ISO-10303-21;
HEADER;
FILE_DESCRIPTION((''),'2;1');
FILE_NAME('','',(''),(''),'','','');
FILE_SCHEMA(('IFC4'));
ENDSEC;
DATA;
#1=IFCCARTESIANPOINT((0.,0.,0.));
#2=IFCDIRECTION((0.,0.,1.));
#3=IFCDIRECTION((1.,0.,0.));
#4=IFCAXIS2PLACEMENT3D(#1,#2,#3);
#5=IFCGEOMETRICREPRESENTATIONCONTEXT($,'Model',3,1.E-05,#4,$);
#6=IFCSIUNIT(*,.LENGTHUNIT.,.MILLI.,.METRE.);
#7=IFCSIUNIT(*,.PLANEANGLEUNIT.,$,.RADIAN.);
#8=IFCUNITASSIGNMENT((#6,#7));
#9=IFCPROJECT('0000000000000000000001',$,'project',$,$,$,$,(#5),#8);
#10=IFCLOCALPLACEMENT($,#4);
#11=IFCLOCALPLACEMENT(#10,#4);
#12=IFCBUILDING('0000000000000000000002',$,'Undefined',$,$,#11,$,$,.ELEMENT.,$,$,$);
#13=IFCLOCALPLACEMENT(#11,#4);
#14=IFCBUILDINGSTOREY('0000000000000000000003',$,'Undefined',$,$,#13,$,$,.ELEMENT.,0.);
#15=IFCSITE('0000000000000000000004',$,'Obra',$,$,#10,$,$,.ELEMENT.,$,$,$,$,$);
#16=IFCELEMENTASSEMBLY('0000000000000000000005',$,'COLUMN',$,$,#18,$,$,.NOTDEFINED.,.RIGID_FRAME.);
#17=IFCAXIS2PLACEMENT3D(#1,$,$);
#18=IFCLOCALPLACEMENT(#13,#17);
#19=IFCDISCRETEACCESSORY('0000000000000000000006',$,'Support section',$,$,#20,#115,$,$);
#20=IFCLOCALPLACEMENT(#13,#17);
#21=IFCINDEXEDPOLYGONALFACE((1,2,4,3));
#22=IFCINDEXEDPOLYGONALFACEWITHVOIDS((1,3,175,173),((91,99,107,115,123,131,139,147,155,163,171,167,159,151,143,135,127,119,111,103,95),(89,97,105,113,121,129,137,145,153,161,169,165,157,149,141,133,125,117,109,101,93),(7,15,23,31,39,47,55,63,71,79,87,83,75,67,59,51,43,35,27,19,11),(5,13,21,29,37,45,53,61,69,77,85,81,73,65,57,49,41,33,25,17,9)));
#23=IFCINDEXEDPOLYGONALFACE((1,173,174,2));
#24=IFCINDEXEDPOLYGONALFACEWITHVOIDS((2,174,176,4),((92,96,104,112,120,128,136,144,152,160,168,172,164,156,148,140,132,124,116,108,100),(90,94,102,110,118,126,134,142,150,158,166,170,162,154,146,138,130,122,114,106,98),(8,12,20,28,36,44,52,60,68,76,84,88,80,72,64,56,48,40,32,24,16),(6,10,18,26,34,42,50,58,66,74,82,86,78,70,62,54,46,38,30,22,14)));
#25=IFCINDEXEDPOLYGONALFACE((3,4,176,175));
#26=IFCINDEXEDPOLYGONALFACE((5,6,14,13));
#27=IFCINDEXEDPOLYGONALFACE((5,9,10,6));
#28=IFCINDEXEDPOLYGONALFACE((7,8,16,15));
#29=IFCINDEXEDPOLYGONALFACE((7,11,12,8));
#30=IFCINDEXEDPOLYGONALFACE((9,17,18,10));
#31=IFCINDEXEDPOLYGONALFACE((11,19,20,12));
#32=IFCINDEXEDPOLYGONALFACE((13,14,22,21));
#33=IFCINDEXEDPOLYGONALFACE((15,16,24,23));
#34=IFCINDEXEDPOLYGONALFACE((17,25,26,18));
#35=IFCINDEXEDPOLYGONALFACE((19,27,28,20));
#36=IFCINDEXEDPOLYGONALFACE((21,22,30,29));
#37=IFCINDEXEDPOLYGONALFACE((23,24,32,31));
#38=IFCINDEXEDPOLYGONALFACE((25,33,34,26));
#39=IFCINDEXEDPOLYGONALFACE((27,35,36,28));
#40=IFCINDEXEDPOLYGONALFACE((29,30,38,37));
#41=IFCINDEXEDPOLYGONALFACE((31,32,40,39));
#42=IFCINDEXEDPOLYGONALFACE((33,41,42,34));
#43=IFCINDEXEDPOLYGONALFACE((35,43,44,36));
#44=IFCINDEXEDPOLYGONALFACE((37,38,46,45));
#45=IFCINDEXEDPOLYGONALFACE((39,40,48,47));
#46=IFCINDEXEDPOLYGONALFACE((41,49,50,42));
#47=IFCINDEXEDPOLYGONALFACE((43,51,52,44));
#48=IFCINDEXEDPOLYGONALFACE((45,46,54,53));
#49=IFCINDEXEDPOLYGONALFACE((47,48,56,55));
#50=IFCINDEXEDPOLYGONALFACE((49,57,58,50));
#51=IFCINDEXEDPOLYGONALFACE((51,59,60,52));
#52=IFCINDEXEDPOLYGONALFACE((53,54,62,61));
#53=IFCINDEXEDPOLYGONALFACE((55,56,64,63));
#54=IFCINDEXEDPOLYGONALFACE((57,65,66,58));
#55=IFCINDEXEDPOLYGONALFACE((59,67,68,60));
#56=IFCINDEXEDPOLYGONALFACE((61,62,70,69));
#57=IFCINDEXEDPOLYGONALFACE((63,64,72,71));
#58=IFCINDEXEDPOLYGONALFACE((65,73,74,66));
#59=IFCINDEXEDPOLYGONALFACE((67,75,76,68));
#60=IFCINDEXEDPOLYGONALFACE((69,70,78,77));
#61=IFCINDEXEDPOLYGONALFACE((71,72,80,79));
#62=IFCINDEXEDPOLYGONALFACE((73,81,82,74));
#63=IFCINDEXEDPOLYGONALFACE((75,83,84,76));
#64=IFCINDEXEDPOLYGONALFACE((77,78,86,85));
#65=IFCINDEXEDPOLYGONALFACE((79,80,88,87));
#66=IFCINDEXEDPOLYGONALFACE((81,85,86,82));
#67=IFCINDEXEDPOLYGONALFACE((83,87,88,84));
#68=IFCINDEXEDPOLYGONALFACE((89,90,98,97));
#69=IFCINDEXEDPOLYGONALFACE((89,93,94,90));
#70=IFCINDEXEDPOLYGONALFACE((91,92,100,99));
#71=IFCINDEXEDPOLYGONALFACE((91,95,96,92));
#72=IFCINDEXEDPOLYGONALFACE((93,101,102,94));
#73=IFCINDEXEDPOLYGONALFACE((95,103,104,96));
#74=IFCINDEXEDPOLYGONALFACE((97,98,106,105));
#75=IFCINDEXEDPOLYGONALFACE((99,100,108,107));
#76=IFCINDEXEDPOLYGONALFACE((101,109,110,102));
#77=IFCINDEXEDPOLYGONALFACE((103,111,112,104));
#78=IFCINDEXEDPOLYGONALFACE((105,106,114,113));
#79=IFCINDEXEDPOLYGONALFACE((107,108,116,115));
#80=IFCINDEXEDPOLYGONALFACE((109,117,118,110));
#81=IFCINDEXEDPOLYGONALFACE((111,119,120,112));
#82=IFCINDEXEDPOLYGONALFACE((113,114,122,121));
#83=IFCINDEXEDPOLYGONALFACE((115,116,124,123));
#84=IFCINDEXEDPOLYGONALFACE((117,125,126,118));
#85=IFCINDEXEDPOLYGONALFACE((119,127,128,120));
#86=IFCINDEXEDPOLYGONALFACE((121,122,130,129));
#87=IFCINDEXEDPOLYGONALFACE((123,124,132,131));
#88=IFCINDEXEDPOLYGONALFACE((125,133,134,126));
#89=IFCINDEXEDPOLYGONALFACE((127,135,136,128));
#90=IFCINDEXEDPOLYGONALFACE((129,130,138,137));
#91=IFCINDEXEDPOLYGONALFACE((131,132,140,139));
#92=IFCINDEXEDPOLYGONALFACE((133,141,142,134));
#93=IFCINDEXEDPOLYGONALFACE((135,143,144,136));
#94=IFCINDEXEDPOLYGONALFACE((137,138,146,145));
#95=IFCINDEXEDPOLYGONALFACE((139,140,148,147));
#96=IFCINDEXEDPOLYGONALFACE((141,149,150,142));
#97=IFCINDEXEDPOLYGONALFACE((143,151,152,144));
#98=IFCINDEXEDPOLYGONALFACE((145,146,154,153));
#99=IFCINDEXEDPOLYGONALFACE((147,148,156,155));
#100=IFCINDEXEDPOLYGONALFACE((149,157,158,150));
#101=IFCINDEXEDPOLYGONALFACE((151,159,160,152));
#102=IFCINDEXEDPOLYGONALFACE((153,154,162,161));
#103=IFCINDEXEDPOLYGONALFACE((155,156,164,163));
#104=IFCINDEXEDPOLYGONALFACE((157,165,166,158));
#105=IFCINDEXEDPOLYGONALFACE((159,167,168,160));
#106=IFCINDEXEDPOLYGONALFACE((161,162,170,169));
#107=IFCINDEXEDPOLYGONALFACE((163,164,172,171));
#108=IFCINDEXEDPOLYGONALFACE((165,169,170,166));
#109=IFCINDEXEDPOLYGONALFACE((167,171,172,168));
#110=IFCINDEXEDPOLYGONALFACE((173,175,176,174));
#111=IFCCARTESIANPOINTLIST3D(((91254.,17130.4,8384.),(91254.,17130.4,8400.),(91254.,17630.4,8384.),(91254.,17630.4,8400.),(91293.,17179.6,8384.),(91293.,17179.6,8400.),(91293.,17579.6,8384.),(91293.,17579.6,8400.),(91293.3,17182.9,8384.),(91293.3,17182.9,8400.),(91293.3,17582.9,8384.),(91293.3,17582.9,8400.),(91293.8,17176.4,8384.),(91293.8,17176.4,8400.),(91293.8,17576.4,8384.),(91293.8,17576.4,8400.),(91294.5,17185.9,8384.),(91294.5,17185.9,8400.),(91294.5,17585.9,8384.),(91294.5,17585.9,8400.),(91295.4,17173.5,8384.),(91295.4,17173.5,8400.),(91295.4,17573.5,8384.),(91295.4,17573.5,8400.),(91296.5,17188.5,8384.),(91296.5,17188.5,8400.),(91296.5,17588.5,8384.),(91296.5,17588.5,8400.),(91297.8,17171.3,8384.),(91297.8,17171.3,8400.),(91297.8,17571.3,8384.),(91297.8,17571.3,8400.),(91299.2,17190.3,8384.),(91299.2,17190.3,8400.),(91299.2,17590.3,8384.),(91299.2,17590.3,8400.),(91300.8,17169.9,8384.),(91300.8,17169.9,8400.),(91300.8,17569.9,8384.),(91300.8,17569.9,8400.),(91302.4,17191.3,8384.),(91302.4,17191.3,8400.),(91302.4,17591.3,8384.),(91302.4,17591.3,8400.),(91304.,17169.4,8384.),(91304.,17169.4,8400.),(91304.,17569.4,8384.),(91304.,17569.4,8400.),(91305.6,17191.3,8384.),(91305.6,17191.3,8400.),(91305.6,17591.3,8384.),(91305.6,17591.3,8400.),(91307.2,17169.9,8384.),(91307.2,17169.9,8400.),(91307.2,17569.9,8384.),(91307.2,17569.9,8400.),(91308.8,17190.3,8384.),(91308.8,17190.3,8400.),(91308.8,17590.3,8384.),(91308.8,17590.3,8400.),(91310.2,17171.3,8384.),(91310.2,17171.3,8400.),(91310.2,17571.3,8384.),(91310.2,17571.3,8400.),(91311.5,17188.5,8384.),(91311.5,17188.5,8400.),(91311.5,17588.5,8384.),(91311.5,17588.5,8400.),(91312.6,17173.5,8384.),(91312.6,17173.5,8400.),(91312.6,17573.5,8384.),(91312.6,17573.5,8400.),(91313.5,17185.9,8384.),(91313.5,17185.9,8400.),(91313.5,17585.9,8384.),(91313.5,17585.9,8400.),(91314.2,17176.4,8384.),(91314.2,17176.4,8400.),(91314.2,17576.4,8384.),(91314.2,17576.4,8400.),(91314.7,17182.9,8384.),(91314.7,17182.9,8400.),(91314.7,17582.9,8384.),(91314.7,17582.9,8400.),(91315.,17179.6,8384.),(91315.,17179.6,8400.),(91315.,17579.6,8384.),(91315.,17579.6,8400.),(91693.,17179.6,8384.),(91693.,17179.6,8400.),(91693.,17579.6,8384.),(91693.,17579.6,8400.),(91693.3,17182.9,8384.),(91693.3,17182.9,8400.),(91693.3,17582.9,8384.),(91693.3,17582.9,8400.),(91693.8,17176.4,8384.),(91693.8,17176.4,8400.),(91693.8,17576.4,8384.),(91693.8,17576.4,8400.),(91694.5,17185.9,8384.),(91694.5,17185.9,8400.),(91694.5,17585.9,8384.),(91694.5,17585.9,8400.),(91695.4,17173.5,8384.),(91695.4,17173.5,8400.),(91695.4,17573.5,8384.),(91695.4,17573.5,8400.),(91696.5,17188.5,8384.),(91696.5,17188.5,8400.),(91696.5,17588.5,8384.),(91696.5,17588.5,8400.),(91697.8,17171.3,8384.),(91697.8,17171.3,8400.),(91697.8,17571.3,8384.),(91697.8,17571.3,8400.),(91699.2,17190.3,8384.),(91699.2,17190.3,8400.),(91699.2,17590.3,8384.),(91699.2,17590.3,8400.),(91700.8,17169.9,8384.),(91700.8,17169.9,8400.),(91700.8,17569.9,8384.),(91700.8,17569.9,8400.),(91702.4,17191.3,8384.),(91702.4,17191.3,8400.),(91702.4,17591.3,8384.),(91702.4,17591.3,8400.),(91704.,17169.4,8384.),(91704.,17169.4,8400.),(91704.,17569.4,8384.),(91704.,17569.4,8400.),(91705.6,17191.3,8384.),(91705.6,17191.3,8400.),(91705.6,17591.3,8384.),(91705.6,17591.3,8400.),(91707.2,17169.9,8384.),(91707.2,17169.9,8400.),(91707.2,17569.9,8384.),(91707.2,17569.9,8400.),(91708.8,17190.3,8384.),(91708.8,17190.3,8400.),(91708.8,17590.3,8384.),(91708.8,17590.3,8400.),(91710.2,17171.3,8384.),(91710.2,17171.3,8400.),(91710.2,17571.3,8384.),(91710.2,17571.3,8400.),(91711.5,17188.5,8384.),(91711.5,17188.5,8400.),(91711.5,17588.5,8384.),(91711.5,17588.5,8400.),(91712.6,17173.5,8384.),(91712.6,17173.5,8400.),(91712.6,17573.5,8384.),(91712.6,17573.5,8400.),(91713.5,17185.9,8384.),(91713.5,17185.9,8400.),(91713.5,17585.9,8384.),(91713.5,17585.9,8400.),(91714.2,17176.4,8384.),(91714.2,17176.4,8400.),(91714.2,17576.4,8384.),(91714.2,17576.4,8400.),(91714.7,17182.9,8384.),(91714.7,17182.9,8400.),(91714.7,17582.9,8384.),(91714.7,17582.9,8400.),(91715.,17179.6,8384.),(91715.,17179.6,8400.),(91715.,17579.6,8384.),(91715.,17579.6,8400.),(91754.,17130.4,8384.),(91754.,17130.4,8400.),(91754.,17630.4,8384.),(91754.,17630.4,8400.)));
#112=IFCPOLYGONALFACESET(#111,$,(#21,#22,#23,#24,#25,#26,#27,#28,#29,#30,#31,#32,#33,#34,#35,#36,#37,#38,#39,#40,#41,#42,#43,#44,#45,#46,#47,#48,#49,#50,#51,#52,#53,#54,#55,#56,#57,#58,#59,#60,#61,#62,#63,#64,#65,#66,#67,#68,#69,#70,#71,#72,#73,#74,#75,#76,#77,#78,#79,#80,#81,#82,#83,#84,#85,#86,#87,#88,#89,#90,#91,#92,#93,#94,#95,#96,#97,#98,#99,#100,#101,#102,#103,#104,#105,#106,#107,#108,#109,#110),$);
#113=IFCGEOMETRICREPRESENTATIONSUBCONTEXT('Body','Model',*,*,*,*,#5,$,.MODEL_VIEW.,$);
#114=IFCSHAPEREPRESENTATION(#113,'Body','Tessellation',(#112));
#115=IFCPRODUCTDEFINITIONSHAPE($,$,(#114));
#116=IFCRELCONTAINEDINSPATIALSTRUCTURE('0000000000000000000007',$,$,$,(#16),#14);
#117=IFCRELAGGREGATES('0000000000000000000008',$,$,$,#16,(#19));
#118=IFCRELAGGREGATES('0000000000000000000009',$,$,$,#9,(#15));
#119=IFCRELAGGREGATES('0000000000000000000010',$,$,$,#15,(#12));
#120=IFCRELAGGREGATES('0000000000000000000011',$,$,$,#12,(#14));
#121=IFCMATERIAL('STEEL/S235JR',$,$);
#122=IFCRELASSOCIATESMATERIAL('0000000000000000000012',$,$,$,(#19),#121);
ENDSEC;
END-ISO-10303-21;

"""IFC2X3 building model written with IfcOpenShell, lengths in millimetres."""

from ifc_helpers import new_model, si_unit, frame, origin_with_axes, origin_2d_with_axis, place, context, subcontext, project, spatial, rectangle, circle, extrude, source, transform, mapped, material, element, aggregate, save


model = new_model("IFC2X3")

# Units and contexts
model_context = context("Model", 3, precision=1e-05, world=origin_with_axes())
body_context = subcontext(model_context, "Body", "Model", "MODEL_VIEW")
ifc_project = project(units=[si_unit("LENGTHUNIT", "METRE", prefix="MILLI"), si_unit("PLANEANGLEUNIT", "RADIAN")], contexts=[model_context])

# Site, building, storey
site_placement = place(None, origin_with_axes())
site = spatial("IfcSite", under=ifc_project, at=site_placement, Name="Obra", CompositionType="ELEMENT")
building_placement = place(site_placement, origin_with_axes())
building = spatial("IfcBuilding", under=site, at=building_placement, Name="Undefined", CompositionType="ELEMENT")
storey_placement = place(building_placement, origin_with_axes())
storey = spatial("IfcBuildingStorey", under=building, at=storey_placement, Name="Undefined", CompositionType="ELEMENT", Elevation=0.0)

# Element assembly
assembly_1_placement = place(storey_placement, origin_with_axes())
assembly_1 = element("IfcElementAssembly", 1, at=assembly_1_placement, inside=storey, Name="COLUMN", AssemblyPlace="NOTDEFINED", PredefinedType="RIGID_FRAME")
ifc_material_1 = material(Name="STEEL/S235JR")

# Discrete accessory, opening
discrete_accessory_1_placement = place(assembly_1_placement, frame((91504.0, 17130.4, 8392.0), z_axis=(-1.0, 0.0, 0.0), x_axis=(0.0, 1.0, 0.0)))
discrete_accessory_1 = element("IfcDiscreteAccessory", 2, at=discrete_accessory_1_placement, material=ifc_material_1, Name="Support section", context=body_context, shape_type="SweptSolid", body=[
    extrude(rectangle(XDim=16.0, YDim=500.0, at=origin_2d_with_axis()), frame((500.0, 0.0, 0.0), z_axis=(-1.0, 0.0, 0.0), x_axis=(0.0, -1.0, 0.0)), (0.0, 0.0, 1.0), 500.0),
])
shared_shape_1 = source(origin_with_axes(), body_context, "Body", "SweptSolid", [
    extrude(circle(Radius=11.0, at=origin_2d_with_axis()), frame((0.0, -0.1, 0.0), z_axis=(0.0, 1.0, 0.0), x_axis=(1.0, 0.0, 0.0)), (0.0, 0.0, 1.0), 16.2),
])
opening_1_placement = place(assembly_1_placement, frame((91504.0, 17583.4, 8400.0), z_axis=(1.0, 0.0, 0.0), x_axis=(0.0, -1.0, 0.0)))
element("IfcOpeningElement", 3, at=opening_1_placement, cuts=discrete_accessory_1, ObjectType="Opening", context=body_context, shape_type="MappedRepresentation", body=[
    mapped(shared_shape_1, transform((3.0, 0.0, 200.0))),
    mapped(shared_shape_1, transform((3.0, 0.0, -200.0))),
    mapped(shared_shape_1, transform((403.0, 0.0, 200.0))),
    mapped(shared_shape_1, transform((403.0, 0.0, -200.0))),
])
aggregate(assembly_1, [discrete_accessory_1])

save(model, "model.ifc")
